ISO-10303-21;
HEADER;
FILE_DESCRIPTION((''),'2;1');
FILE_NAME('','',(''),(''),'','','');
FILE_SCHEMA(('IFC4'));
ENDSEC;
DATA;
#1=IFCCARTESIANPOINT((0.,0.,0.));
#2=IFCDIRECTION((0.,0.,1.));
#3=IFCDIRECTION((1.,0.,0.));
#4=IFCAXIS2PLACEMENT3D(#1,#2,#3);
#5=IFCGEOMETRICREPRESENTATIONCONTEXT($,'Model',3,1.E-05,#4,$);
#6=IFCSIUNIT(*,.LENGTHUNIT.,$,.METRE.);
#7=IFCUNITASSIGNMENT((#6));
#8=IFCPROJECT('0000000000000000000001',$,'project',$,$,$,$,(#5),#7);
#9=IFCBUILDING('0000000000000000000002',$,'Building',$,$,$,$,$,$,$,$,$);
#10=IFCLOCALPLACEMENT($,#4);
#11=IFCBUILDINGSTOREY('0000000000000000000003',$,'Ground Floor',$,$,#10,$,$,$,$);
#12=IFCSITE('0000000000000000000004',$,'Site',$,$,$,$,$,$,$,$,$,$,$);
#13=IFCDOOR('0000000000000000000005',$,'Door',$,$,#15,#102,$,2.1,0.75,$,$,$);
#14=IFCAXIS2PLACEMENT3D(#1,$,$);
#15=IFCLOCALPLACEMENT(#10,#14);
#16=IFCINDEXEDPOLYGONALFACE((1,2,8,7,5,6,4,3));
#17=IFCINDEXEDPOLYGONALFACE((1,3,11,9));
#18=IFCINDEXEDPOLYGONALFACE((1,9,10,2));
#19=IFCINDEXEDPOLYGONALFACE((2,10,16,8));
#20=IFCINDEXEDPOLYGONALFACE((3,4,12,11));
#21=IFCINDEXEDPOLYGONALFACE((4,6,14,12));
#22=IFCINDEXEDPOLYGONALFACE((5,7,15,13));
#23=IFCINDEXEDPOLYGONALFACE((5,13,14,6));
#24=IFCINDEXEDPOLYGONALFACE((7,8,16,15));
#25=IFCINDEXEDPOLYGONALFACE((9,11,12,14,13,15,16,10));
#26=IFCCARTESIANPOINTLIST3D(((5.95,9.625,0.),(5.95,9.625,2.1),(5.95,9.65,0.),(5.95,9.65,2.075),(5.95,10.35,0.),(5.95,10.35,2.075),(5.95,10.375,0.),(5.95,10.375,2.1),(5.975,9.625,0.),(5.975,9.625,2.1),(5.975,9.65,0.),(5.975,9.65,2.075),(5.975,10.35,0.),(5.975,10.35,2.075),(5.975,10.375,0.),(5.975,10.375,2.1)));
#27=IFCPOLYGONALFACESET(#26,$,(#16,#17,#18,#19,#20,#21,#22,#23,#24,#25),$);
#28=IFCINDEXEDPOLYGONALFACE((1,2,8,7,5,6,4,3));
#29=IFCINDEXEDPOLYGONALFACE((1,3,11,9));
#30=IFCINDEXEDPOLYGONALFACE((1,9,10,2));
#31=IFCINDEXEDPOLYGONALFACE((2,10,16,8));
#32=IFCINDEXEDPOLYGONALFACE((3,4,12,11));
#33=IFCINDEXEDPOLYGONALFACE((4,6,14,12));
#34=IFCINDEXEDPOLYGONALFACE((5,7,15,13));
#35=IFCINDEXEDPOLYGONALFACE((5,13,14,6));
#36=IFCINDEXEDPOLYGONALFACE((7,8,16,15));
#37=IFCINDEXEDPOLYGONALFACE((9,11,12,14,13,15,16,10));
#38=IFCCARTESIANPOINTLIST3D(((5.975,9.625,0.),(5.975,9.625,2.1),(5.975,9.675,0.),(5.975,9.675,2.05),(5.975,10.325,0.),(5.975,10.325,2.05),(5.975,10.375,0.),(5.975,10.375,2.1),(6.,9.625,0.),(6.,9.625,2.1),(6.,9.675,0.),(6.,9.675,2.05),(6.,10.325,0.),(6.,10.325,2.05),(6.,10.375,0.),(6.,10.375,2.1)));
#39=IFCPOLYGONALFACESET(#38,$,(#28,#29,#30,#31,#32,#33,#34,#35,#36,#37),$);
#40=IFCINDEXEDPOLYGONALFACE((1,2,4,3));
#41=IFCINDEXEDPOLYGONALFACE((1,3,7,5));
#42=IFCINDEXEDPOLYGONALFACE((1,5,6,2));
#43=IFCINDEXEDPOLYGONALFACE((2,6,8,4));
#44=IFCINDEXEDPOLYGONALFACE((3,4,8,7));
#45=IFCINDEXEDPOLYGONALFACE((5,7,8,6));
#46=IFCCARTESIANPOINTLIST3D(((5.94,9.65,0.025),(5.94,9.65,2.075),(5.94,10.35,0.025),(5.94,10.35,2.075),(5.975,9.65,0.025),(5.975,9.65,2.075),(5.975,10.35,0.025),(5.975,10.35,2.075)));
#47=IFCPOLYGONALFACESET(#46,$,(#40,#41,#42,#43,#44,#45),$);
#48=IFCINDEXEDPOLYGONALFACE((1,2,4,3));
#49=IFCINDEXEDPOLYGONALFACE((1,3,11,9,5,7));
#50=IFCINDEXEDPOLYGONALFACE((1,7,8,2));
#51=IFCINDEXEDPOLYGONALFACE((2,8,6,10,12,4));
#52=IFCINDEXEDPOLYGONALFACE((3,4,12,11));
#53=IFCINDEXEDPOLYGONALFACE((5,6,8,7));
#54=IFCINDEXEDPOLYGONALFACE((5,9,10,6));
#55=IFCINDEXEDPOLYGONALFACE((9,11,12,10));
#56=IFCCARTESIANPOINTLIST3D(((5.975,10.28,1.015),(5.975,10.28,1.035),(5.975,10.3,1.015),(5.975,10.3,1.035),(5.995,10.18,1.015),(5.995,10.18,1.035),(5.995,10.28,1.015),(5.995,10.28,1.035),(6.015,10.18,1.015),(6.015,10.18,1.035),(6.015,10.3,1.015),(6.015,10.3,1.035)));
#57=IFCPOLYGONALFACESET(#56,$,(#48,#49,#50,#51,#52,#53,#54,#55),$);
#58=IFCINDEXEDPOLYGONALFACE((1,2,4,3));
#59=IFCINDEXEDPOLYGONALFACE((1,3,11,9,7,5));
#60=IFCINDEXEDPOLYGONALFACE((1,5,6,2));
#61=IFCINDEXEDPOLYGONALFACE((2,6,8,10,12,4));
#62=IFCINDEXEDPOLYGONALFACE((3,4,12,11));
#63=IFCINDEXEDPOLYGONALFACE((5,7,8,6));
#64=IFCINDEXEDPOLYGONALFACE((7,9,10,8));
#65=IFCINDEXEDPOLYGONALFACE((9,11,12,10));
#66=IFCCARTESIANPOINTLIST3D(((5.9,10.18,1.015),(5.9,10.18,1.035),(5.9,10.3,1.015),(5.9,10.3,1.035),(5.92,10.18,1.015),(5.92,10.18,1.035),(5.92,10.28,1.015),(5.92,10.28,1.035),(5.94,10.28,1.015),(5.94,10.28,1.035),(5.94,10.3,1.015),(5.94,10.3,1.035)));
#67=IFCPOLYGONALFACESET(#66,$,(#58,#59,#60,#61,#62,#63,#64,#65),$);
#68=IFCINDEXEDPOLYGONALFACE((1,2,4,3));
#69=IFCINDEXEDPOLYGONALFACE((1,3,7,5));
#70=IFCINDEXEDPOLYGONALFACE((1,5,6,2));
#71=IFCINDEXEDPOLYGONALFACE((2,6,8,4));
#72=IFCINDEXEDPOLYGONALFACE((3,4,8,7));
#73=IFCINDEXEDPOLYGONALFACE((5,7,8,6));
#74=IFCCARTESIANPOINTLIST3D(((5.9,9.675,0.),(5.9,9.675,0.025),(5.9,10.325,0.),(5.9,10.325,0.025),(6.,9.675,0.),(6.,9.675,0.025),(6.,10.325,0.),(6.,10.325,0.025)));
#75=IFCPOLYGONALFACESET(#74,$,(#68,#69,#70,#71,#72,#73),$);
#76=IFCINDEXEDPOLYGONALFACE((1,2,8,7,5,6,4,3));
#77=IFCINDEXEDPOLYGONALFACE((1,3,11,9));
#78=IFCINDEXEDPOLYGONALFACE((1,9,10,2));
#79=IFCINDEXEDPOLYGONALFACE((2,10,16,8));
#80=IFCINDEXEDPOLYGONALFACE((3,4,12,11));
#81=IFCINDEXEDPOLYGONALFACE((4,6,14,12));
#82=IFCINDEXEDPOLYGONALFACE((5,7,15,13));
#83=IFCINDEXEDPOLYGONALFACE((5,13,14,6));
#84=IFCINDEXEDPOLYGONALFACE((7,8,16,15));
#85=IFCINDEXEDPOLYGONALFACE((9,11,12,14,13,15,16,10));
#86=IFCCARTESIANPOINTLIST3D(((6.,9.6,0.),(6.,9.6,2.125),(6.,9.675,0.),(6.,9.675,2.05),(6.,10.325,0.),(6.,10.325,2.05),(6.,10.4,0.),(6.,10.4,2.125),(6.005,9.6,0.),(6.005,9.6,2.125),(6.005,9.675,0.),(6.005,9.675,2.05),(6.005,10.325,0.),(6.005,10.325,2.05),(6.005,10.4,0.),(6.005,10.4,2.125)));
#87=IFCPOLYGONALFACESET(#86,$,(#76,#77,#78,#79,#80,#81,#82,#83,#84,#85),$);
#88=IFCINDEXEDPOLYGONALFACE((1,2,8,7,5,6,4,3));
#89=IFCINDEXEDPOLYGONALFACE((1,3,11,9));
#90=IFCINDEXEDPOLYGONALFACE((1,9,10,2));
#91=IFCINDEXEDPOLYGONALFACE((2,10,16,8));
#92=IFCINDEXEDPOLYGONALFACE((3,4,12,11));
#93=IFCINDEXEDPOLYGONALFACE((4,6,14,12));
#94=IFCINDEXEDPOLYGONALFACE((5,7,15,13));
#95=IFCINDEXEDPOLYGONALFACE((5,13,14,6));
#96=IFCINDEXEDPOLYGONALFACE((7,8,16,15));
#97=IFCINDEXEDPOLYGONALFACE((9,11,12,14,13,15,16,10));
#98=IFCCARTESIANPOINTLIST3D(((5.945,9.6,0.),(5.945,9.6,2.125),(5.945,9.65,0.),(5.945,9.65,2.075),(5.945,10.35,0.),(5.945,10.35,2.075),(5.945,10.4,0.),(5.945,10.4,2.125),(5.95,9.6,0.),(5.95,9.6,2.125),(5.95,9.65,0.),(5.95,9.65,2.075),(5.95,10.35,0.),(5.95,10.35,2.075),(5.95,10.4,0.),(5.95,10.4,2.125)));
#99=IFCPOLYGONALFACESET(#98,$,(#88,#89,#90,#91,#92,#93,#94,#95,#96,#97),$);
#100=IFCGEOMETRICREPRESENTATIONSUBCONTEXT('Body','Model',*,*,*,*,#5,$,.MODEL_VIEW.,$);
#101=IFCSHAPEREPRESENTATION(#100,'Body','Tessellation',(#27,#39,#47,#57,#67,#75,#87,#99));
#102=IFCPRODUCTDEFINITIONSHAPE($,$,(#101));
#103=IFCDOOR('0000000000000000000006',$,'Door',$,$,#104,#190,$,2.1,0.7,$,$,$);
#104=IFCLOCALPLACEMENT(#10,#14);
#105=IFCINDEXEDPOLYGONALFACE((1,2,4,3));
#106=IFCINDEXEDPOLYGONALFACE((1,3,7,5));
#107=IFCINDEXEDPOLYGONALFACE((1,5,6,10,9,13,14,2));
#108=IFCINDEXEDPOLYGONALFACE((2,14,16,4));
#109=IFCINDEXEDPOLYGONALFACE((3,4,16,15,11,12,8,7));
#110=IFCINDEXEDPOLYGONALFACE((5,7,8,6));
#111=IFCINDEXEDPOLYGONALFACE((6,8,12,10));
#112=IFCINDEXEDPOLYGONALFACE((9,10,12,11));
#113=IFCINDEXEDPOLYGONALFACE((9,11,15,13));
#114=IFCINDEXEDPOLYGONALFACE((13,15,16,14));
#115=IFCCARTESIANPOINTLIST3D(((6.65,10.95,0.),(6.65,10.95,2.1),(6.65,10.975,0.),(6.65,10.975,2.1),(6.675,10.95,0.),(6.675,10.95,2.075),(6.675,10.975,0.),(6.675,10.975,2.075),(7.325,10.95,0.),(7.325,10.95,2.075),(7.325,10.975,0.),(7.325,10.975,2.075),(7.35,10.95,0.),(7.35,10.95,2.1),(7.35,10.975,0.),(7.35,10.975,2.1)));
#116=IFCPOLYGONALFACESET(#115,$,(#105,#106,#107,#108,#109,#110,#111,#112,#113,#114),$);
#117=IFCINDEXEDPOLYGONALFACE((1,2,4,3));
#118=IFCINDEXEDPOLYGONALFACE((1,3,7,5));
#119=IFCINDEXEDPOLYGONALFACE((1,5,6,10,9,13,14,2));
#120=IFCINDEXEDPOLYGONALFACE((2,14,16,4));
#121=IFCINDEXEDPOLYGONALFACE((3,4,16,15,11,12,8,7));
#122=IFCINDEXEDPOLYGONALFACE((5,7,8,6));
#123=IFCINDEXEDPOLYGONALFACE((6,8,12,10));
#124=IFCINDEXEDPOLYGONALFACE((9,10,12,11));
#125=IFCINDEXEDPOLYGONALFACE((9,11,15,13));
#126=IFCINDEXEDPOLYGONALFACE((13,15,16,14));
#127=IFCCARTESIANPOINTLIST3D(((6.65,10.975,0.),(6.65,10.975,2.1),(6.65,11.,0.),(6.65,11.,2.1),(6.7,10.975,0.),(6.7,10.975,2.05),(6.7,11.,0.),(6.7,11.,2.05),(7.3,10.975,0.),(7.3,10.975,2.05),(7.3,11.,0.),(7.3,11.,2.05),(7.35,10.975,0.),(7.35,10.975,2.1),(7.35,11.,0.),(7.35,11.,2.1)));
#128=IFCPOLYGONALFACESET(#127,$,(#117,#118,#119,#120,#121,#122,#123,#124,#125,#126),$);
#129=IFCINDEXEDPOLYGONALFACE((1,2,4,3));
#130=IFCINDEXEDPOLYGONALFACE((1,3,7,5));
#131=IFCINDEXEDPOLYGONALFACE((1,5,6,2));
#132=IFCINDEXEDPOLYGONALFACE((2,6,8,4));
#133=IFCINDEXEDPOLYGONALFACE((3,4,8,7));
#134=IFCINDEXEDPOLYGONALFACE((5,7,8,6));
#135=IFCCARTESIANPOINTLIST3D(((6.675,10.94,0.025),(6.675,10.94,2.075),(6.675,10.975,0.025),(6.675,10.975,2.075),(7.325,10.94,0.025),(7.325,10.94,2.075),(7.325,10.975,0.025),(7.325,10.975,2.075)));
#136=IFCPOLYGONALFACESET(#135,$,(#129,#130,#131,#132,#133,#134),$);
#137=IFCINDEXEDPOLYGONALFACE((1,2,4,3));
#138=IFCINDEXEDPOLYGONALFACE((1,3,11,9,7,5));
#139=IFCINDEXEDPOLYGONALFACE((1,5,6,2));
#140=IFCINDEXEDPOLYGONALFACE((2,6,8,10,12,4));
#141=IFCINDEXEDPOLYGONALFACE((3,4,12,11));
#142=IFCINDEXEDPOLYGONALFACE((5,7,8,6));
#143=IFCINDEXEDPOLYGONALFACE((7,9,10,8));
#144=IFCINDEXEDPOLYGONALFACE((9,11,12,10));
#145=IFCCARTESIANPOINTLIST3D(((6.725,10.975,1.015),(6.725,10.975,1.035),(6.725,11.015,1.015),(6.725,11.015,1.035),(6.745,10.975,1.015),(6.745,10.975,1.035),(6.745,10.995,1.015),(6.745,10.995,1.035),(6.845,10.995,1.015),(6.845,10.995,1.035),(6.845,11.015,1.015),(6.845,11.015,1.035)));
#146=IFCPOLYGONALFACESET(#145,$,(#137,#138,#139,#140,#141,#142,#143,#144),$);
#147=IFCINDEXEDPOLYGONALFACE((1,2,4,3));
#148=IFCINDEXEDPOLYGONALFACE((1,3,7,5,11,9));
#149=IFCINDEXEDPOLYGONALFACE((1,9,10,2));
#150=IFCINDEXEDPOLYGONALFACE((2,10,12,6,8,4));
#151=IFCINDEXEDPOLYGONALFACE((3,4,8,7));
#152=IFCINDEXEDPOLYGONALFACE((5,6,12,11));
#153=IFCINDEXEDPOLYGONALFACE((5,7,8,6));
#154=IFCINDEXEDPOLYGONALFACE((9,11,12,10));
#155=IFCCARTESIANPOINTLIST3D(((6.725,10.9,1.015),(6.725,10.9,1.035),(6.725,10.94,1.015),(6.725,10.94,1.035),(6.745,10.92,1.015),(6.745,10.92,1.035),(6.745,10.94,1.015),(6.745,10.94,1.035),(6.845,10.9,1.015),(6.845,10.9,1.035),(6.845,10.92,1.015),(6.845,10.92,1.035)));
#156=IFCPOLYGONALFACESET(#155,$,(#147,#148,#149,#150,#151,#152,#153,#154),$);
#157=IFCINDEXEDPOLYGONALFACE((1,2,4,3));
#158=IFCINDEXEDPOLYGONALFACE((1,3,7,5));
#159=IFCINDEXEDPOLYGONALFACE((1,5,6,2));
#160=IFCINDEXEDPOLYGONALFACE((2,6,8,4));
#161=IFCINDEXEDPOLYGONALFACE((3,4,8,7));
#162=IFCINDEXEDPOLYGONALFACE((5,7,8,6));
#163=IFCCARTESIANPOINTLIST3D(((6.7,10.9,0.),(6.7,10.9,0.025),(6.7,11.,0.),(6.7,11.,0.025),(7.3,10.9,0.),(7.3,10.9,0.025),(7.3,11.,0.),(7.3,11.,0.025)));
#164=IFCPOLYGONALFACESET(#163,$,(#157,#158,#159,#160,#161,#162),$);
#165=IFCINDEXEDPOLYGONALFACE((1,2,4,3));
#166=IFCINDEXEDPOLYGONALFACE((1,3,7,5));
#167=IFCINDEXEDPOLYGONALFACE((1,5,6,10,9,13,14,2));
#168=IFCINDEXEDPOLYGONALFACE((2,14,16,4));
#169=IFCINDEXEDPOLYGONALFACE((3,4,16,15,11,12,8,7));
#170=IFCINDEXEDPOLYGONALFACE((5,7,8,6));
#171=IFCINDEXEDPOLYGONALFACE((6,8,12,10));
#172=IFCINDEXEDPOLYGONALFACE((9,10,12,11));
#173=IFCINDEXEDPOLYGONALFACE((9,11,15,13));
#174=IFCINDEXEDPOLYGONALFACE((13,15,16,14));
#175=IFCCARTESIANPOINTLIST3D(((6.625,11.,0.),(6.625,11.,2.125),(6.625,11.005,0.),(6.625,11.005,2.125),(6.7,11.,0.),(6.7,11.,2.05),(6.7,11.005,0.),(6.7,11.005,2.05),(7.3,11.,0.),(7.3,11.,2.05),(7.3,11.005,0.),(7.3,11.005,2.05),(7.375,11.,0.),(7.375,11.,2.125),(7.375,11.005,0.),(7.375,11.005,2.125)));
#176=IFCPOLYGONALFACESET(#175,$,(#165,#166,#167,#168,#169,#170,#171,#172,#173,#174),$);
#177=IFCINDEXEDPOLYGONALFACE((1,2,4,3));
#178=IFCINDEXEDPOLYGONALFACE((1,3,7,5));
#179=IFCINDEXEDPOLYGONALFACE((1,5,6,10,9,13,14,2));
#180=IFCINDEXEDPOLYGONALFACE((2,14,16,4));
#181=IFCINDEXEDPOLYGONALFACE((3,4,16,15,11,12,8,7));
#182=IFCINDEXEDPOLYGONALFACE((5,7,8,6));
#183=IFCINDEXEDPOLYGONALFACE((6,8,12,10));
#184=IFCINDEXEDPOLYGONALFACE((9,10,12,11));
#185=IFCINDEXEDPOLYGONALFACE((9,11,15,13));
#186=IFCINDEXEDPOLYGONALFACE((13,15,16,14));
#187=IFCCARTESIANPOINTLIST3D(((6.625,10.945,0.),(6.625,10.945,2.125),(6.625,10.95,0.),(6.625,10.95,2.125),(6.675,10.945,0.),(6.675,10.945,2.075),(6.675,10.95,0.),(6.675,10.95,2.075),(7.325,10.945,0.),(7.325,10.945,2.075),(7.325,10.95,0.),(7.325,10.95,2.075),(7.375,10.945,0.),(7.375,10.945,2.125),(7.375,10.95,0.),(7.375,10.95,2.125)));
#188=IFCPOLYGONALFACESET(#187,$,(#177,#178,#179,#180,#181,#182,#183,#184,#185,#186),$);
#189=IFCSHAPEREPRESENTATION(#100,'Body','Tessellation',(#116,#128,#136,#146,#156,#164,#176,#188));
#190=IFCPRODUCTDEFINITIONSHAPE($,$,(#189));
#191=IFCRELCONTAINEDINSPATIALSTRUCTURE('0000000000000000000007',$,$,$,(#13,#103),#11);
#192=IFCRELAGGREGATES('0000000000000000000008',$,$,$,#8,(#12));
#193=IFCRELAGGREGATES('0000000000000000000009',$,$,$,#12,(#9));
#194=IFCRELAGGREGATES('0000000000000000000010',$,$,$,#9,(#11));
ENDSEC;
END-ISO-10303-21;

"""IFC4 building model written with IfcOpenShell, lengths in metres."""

from ifc_helpers import new_model, si_unit, frame, origin_with_axes, place, context, subcontext, project, spatial, line, indexed_curve, outline, extrude, element, save


model = new_model("IFC4")

# Units and contexts
model_context = context("Model", 3, precision=1e-05, world=origin_with_axes())
body_context = subcontext(model_context, "Body", "Model", "MODEL_VIEW")
ifc_project = project(units=[si_unit("LENGTHUNIT", "METRE")], contexts=[model_context])

# Site, building, storey
site = spatial("IfcSite", under=ifc_project, Name="Site")
building = spatial("IfcBuilding", under=site, Name="Building")
storey_placement = place(None, origin_with_axes())
storey = spatial("IfcBuildingStorey", under=building, at=storey_placement, Name="Ground Floor")

# Doors
door_1_placement = place(storey_placement, frame((6.0, 9.625, 0.0), z_axis=(0.0, 0.0, 1.0), x_axis=(0.0, 1.0, 0.0)))
element("IfcDoor", 1, at=door_1_placement, inside=storey, Name="Door", OverallHeight=2.1, OverallWidth=0.75, context=body_context, shape_type="SweptSolid", body=[
    extrude(outline(indexed_curve([(0.0, 0.0), (0.0, 2.1), (0.75, 2.1), (0.75, 0.0), (0.725, 0.0), (0.725, 2.075), (0.025, 2.075), (0.025, 0.0)], segments=[line(1, 2, 3, 4, 5, 6, 7, 8, 1)])), frame((0.0, 0.025, 0.0), z_axis=(0.0, -1.0, 0.0), x_axis=(1.0, 0.0, 0.0)), (0.0, 0.0, -1.0), 0.025),
    extrude(outline(indexed_curve([(0.0, 0.0), (0.0, 2.1), (0.75, 2.1), (0.75, 0.0), (0.7, 0.0), (0.7, 2.05), (0.05, 2.05), (0.05, 0.0)], segments=[line(1, 2, 3, 4, 5, 6, 7, 8, 1)])), frame((0.0, 0.0, 0.0), z_axis=(0.0, -1.0, 0.0), x_axis=(1.0, 0.0, 0.0)), (0.0, 0.0, -1.0), 0.025),
    extrude(outline(indexed_curve([(0.0, 0.0), (0.7, 0.0), (0.7, 0.035), (0.0, 0.035)], segments=[line(1, 2, 3, 4, 1)])), frame((0.025, 0.025, 0.025), z_axis=(0.0, 0.0, 1.0), x_axis=(1.0, 0.0, 0.0)), (0.0, 0.0, 1.0), 2.05),
    extrude(outline(indexed_curve([(0.0, 0.0), (0.0, -0.04), (-0.12, -0.04), (-0.12, -0.02), (-0.02, -0.02), (-0.02, 0.0)], segments=[line(1, 2, 3, 4, 5, 6, 1)])), frame((0.675, 0.025, 1.015), z_axis=(0.0, 0.0, 1.0), x_axis=(1.0, 0.0, 0.0)), (0.0, 0.0, 1.0), 0.02),
    extrude(outline(indexed_curve([(0.0, 0.0), (0.0, 0.04), (-0.12, 0.04), (-0.12, 0.02), (-0.02, 0.02), (-0.02, 0.0)], segments=[line(1, 2, 3, 4, 5, 6, 1)])), frame((0.675, 0.06, 1.015), z_axis=(0.0, 0.0, 1.0), x_axis=(1.0, 0.0, 0.0)), (0.0, 0.0, 1.0), 0.02),
    extrude(outline(indexed_curve([(0.0, 0.0), (0.65, 0.0), (0.65, 0.1), (0.0, 0.1)], segments=[line(1, 2, 3, 4, 1)])), frame((0.05, 0.0, 0.0), z_axis=(0.0, 0.0, 1.0), x_axis=(1.0, 0.0, 0.0)), (0.0, 0.0, 1.0), 0.025),
    extrude(outline(indexed_curve([(0.0, 0.0), (0.0, 2.125), (0.8, 2.125), (0.8, 0.0), (0.725, 0.0), (0.725, 2.05), (0.075, 2.05), (0.075, 0.0)], segments=[line(1, 2, 3, 4, 5, 6, 7, 8, 1)])), frame((-0.025, -0.005, 0.0), z_axis=(0.0, -1.0, 0.0), x_axis=(1.0, 0.0, 0.0)), (0.0, 0.0, -1.0), 0.005),
    extrude(outline(indexed_curve([(0.0, 0.0), (0.0, 2.125), (0.8, 2.125), (0.8, 0.0), (0.75, 0.0), (0.75, 2.075), (0.05, 2.075), (0.05, 0.0)], segments=[line(1, 2, 3, 4, 5, 6, 7, 8, 1)])), frame((-0.025, 0.05, 0.0), z_axis=(0.0, -1.0, 0.0), x_axis=(1.0, 0.0, 0.0)), (0.0, 0.0, -1.0), 0.005),
])
door_2_placement = place(storey_placement, frame((7.35, 11.0, 0.0), z_axis=(0.0, 0.0, 1.0), x_axis=(-1.0, 0.0, 0.0)))
element("IfcDoor", 2, at=door_2_placement, inside=storey, Name="Door", OverallHeight=2.1, OverallWidth=0.7, context=body_context, shape_type="SweptSolid", body=[
    extrude(outline(indexed_curve([(0.0, 0.0), (0.0, 2.1), (0.7, 2.1), (0.7, 0.0), (0.675, 0.0), (0.675, 2.075), (0.025, 2.075), (0.025, 0.0)], segments=[line(1, 2, 3, 4, 5, 6, 7, 8, 1)])), frame((0.0, 0.025, 0.0), z_axis=(0.0, -1.0, 0.0), x_axis=(1.0, 0.0, 0.0)), (0.0, 0.0, -1.0), 0.025),
    extrude(outline(indexed_curve([(0.0, 0.0), (0.0, 2.1), (0.7, 2.1), (0.7, 0.0), (0.65, 0.0), (0.65, 2.05), (0.05, 2.05), (0.05, 0.0)], segments=[line(1, 2, 3, 4, 5, 6, 7, 8, 1)])), frame((0.0, 0.0, 0.0), z_axis=(0.0, -1.0, 0.0), x_axis=(1.0, 0.0, 0.0)), (0.0, 0.0, -1.0), 0.025),
    extrude(outline(indexed_curve([(0.0, 0.0), (0.65, 0.0), (0.65, 0.035), (0.0, 0.035)], segments=[line(1, 2, 3, 4, 1)])), frame((0.025, 0.025, 0.025), z_axis=(0.0, 0.0, 1.0), x_axis=(1.0, 0.0, 0.0)), (0.0, 0.0, 1.0), 2.05),
    extrude(outline(indexed_curve([(0.0, 0.0), (0.0, -0.04), (-0.12, -0.04), (-0.12, -0.02), (-0.02, -0.02), (-0.02, 0.0)], segments=[line(1, 2, 3, 4, 5, 6, 1)])), frame((0.625, 0.025, 1.015), z_axis=(0.0, 0.0, 1.0), x_axis=(1.0, 0.0, 0.0)), (0.0, 0.0, 1.0), 0.02),
    extrude(outline(indexed_curve([(0.0, 0.0), (0.0, 0.04), (-0.12, 0.04), (-0.12, 0.02), (-0.02, 0.02), (-0.02, 0.0)], segments=[line(1, 2, 3, 4, 5, 6, 1)])), frame((0.625, 0.06, 1.015), z_axis=(0.0, 0.0, 1.0), x_axis=(1.0, 0.0, 0.0)), (0.0, 0.0, 1.0), 0.02),
    extrude(outline(indexed_curve([(0.0, 0.0), (0.6, 0.0), (0.6, 0.1), (0.0, 0.1)], segments=[line(1, 2, 3, 4, 1)])), frame((0.05, 0.0, 0.0), z_axis=(0.0, 0.0, 1.0), x_axis=(1.0, 0.0, 0.0)), (0.0, 0.0, 1.0), 0.025),
    extrude(outline(indexed_curve([(0.0, 0.0), (0.0, 2.125), (0.75, 2.125), (0.75, 0.0), (0.675, 0.0), (0.675, 2.05), (0.075, 2.05), (0.075, 0.0)], segments=[line(1, 2, 3, 4, 5, 6, 7, 8, 1)])), frame((-0.025, -0.005, 0.0), z_axis=(0.0, -1.0, 0.0), x_axis=(1.0, 0.0, 0.0)), (0.0, 0.0, -1.0), 0.005),
    extrude(outline(indexed_curve([(0.0, 0.0), (0.0, 2.125), (0.75, 2.125), (0.75, 0.0), (0.7, 0.0), (0.7, 2.075), (0.05, 2.075), (0.05, 0.0)], segments=[line(1, 2, 3, 4, 5, 6, 7, 8, 1)])), frame((-0.025, 0.05, 0.0), z_axis=(0.0, -1.0, 0.0), x_axis=(1.0, 0.0, 0.0)), (0.0, 0.0, -1.0), 0.005),
])

save(model, "model.ifc")
